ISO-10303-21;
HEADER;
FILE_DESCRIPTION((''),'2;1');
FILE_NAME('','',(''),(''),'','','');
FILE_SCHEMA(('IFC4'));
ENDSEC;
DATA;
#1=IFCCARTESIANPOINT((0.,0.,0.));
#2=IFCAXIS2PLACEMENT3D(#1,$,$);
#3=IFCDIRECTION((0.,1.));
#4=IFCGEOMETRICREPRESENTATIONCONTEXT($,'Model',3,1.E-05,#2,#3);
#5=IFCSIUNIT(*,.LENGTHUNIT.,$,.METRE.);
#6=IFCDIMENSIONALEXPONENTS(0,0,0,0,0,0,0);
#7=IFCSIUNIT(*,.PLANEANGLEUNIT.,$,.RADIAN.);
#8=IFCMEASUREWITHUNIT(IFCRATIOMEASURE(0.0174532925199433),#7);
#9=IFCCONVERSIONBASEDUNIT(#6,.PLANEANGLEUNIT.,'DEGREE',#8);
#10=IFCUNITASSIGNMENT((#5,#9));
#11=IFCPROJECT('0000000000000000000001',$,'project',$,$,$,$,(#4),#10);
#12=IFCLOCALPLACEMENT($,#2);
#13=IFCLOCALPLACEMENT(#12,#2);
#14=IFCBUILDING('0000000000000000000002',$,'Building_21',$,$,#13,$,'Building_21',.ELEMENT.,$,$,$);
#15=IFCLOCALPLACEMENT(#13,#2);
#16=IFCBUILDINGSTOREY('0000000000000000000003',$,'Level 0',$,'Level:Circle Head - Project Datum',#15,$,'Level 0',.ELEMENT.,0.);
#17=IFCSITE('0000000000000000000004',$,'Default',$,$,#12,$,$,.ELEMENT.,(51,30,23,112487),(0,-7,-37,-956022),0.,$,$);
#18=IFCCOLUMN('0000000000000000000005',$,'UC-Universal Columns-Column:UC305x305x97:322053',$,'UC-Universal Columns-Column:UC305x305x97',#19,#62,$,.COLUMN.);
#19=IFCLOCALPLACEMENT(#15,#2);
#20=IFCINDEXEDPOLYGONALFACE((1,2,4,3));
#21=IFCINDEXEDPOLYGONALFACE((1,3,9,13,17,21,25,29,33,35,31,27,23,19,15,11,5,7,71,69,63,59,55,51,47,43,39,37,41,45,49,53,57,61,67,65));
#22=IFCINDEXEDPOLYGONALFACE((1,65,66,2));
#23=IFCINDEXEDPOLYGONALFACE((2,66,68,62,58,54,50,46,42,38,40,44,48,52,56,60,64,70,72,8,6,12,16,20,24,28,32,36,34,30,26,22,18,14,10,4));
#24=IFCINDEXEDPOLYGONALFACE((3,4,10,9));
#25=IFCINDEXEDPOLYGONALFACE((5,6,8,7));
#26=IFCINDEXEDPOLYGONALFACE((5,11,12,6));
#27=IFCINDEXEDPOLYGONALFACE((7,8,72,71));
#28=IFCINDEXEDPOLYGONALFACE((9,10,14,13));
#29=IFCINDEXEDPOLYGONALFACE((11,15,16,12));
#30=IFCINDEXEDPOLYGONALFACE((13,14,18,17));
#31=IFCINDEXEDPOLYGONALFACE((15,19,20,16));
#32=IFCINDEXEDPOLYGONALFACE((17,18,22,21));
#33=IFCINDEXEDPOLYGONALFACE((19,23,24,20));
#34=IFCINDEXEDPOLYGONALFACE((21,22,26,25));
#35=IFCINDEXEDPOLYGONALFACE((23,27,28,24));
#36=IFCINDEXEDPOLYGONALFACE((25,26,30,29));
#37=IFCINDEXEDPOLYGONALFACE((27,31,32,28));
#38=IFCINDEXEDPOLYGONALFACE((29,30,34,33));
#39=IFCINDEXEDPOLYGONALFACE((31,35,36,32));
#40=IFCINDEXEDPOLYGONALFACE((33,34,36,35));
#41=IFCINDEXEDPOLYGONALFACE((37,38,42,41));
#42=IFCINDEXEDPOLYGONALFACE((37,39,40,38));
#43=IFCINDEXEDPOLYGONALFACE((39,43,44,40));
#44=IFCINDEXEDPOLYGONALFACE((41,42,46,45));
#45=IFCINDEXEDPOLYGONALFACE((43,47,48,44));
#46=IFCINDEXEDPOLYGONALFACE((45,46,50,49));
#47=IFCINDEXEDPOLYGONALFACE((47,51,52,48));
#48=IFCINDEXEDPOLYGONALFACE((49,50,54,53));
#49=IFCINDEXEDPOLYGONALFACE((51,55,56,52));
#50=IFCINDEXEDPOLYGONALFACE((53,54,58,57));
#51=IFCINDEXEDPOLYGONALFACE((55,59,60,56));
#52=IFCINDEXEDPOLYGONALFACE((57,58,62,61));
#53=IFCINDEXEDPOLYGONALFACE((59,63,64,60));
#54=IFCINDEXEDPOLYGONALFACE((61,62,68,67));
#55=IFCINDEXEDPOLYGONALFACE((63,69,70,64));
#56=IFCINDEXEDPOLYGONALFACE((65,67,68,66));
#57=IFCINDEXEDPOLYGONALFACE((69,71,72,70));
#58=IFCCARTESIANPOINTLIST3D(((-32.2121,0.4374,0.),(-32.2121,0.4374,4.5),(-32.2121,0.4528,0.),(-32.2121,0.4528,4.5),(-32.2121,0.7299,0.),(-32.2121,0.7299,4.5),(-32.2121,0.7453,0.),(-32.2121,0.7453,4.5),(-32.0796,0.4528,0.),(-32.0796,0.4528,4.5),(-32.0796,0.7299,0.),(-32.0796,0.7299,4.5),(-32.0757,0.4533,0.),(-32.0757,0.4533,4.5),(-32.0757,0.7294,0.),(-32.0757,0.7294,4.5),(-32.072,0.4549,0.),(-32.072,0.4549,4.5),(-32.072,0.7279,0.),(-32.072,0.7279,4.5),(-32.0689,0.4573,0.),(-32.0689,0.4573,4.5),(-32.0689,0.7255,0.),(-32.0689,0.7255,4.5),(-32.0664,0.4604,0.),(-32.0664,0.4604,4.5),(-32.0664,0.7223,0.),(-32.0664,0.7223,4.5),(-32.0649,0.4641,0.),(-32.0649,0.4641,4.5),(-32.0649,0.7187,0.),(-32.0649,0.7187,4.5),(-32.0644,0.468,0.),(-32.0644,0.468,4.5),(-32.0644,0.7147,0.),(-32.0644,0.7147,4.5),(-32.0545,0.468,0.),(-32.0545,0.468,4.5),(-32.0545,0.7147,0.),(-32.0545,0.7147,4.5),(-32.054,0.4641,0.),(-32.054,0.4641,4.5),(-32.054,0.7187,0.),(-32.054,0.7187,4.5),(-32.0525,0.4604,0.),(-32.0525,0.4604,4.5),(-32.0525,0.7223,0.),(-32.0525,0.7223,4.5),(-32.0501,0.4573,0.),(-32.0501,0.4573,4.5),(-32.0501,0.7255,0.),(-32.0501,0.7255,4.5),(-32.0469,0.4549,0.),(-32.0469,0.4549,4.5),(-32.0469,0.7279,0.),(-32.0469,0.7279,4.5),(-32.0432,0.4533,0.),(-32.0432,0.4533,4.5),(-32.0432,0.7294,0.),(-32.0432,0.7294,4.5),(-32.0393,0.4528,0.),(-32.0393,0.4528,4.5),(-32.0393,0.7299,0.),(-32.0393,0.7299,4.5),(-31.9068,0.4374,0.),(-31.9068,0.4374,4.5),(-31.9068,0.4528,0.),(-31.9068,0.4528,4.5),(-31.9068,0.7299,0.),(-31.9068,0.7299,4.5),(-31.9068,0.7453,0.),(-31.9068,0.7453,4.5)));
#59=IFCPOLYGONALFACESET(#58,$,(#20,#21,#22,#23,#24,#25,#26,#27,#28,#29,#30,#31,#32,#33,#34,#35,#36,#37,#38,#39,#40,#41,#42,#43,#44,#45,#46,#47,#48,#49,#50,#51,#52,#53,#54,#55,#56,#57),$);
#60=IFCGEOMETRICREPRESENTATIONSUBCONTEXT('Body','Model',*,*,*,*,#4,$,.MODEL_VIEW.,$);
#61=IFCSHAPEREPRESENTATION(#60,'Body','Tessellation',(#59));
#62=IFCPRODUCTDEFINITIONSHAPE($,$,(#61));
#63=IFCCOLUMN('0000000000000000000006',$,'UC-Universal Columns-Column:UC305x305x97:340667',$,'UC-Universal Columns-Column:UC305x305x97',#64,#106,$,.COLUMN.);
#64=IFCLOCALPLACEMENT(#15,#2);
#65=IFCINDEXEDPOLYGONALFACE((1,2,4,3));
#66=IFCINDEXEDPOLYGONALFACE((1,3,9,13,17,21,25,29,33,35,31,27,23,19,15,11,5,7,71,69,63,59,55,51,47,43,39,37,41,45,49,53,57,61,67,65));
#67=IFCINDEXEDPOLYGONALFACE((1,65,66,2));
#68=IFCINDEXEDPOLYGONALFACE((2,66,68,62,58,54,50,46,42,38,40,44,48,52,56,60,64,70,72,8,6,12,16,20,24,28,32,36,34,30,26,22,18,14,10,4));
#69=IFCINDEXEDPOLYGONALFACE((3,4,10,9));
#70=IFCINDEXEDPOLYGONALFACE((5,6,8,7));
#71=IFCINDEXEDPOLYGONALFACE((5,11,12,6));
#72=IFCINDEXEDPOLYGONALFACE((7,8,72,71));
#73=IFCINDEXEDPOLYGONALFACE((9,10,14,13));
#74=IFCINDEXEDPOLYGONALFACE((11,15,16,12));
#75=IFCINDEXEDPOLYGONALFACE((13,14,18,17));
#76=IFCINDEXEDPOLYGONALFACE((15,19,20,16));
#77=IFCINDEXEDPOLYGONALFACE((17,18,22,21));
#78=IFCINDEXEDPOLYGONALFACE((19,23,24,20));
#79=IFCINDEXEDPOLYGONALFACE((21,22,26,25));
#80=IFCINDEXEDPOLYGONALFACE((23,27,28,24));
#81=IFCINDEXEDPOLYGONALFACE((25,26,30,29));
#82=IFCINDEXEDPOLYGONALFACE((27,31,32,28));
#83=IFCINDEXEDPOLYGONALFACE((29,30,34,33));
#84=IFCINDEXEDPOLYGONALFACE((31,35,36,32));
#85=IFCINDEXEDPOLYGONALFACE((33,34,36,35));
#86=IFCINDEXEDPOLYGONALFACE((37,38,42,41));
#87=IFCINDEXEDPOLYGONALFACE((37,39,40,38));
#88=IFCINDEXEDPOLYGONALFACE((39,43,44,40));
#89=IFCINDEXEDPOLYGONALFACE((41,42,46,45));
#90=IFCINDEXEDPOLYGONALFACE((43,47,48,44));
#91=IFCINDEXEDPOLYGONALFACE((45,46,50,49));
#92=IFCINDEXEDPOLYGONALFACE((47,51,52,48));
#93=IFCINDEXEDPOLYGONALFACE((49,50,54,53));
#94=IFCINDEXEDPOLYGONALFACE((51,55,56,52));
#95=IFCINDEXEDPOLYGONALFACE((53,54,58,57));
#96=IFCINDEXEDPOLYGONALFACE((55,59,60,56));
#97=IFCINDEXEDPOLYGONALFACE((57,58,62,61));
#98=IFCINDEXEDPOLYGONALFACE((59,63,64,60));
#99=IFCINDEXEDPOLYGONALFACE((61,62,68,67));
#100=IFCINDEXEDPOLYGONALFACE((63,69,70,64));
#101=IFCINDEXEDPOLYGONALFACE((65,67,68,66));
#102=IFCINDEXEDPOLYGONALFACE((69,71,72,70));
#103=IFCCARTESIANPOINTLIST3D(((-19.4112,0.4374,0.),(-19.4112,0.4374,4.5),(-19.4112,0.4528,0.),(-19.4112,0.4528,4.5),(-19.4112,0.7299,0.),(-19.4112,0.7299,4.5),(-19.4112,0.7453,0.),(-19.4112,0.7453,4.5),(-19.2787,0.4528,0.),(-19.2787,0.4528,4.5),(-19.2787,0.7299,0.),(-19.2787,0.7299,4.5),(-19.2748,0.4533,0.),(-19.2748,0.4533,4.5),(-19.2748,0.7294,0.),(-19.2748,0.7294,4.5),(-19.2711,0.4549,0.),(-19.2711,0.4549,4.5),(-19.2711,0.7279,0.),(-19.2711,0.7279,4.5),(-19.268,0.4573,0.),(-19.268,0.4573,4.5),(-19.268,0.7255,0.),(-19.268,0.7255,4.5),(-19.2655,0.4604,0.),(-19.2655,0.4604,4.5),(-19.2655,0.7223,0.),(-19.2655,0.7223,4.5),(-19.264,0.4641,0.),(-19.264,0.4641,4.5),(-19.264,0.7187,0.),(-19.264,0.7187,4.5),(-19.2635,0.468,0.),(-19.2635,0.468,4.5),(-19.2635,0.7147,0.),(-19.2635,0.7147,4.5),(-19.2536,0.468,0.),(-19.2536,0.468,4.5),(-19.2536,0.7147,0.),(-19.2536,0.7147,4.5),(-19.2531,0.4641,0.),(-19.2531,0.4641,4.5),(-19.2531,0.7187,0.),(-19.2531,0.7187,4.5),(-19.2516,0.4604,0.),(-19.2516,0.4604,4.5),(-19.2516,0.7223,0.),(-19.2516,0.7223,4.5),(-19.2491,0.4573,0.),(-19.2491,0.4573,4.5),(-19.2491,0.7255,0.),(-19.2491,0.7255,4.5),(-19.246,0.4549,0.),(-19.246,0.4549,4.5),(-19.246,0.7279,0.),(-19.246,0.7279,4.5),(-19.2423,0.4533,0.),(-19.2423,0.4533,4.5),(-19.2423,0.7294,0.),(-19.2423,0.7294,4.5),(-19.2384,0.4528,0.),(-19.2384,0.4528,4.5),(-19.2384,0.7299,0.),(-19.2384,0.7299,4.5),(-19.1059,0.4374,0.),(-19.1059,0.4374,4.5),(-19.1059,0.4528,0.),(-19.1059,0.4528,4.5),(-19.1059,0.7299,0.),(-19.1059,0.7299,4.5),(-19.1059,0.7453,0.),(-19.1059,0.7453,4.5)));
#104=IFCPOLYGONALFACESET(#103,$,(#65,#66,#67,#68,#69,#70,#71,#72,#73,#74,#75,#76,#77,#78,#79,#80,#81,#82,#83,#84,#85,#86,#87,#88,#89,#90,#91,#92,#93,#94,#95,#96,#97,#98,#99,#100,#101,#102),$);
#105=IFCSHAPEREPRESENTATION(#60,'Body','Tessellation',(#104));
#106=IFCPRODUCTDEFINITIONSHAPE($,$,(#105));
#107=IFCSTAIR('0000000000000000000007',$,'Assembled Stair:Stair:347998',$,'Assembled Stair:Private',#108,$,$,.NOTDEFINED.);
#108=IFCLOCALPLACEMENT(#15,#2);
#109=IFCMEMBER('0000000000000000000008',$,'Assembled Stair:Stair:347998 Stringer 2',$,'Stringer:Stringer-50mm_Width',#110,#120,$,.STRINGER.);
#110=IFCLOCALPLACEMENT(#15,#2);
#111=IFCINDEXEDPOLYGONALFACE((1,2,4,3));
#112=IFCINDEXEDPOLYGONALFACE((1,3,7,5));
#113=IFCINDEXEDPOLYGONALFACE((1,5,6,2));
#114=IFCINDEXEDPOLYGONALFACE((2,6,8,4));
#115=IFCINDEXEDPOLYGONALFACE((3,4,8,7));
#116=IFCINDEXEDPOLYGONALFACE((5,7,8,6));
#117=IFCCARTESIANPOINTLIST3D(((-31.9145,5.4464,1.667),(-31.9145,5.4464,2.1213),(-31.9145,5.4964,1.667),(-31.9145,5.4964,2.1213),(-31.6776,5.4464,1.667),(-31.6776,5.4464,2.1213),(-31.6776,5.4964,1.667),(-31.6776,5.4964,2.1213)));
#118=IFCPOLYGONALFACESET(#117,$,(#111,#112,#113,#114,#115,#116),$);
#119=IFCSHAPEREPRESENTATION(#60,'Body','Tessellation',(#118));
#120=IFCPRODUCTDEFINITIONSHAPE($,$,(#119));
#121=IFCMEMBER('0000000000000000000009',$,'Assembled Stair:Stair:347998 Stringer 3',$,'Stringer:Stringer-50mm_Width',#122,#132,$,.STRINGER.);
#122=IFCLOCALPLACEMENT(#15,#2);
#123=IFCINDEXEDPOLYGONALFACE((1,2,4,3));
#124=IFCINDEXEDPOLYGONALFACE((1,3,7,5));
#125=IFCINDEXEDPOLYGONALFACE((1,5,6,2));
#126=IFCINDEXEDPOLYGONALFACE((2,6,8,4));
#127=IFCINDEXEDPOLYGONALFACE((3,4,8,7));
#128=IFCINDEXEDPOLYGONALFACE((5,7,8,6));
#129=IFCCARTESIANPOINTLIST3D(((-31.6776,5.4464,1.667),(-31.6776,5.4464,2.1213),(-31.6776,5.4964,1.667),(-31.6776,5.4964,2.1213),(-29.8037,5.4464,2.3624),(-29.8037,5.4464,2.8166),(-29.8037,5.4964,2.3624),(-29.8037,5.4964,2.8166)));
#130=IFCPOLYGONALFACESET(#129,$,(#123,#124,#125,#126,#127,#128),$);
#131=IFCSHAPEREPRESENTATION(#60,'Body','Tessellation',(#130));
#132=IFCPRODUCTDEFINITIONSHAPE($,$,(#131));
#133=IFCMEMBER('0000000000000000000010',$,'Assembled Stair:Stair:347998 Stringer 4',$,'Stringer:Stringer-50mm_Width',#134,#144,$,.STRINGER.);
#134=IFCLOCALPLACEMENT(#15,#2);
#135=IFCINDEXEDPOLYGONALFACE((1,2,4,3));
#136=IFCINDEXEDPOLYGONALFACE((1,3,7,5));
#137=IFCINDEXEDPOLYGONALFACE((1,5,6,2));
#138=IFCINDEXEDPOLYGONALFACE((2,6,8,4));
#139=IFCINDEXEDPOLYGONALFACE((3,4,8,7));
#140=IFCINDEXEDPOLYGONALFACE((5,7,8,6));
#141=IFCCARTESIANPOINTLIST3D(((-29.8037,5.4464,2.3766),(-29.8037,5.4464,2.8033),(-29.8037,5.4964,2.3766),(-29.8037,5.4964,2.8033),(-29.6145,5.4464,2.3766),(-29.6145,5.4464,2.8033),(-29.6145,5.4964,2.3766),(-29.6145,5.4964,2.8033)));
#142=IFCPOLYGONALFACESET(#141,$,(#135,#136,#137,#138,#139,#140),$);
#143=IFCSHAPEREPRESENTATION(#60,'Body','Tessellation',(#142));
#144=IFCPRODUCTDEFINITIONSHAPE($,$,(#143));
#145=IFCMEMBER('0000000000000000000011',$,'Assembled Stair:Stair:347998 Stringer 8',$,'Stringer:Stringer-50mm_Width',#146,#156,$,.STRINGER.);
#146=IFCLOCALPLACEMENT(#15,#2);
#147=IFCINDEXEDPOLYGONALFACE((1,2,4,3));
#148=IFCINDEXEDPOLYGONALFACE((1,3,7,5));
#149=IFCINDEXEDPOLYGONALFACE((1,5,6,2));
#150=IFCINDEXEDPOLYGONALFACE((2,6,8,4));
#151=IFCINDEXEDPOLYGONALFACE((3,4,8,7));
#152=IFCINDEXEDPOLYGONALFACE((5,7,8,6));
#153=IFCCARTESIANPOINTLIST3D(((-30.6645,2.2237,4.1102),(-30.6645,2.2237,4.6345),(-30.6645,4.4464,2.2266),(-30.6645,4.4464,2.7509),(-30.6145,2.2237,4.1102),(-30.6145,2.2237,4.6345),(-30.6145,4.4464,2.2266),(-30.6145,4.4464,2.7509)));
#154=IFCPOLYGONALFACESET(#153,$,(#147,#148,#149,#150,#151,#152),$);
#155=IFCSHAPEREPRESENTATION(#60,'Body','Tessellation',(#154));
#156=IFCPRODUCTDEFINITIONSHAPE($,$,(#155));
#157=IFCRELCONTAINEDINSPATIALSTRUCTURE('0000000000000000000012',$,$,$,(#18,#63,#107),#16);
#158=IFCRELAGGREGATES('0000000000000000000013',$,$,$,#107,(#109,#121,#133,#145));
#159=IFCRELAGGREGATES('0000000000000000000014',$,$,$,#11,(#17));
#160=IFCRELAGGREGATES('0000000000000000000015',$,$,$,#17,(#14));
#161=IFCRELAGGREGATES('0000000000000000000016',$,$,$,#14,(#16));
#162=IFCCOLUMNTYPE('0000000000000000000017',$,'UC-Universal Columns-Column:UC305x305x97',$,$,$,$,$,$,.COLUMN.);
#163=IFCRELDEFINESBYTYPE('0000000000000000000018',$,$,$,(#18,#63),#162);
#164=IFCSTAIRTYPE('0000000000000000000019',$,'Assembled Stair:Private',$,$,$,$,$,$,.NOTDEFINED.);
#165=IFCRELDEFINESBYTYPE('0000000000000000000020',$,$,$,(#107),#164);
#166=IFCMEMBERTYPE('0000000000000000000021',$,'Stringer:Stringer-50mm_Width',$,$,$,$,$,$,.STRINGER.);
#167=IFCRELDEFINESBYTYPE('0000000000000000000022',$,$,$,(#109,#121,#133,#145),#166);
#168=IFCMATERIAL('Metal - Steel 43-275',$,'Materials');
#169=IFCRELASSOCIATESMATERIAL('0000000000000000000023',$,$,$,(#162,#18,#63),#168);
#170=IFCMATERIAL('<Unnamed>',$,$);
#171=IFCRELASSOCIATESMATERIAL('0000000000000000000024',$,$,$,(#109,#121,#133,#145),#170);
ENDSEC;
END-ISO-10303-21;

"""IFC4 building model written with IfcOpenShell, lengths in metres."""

from ifc_helpers import new_model, entity, si_unit, converted_unit, direction, frame, frame_2d, origin, place, context, subcontext, project, spatial, polyline, circle_curve, parameter, trimmed, segment, composite_curve, rectangle, i_section, outline, extrude, source, transform, mapped, material, material_profile, profile_set, profile_usage, type_object, type_shapes, element, aggregate, save


model = new_model("IFC4")

# Units and contexts
model_context = context("Model", 3, precision=1e-05, world=origin(), true_north=direction((0.0, 1.0)))
body_context = subcontext(model_context, "Body", "Model", "MODEL_VIEW")
ifc_project = project(units=[si_unit("LENGTHUNIT", "METRE"), converted_unit("PLANEANGLEUNIT", "DEGREE", entity("IfcRatioMeasure", 0.0174532925199433), si_unit("PLANEANGLEUNIT", "RADIAN"), dimensions=[0, 0, 0, 0, 0, 0, 0])], contexts=[model_context])

# Site, building, storey
site_placement = place(None, origin())
site = spatial("IfcSite", under=ifc_project, at=site_placement, Name="Default", CompositionType="ELEMENT", RefLatitude=(51, 30, 23, 112487), RefLongitude=(0, -7, -37, -956022), RefElevation=0.0)
building_placement = place(site_placement, origin())
building = spatial("IfcBuilding", under=site, at=building_placement, Name="Building_21", LongName="Building_21", CompositionType="ELEMENT")
storey_placement = place(building_placement, origin())
storey = spatial("IfcBuildingStorey", under=building, at=storey_placement, Name="Level 0", ObjectType="Level:Circle Head - Project Datum", LongName="Level 0", CompositionType="ELEMENT", Elevation=0.0)

# Columns
ifc_material_1 = material(Name="Metal - Steel 43-275", Category="Materials")
ifc_material_profile_1 = material_profile(ifc_material_1, outline(composite_curve([segment(polyline([(-0.1527, 0.154, 0.0), (0.1527, 0.154, 0.0)]), True, "CONTINUOUS"), segment(polyline([(0.1527, 0.154, 0.0), (0.1527, 0.1386, 0.0)]), True, "CONTINUOUS"), segment(polyline([(0.1527, 0.1386, 0.0), (0.0201, 0.1386, 0.0)]), True, "CONTINUOUS"), segment(trimmed(circle_curve(frame((0.0201, 0.1234, 0.0)), 0.0152), [parameter(90.0)], [parameter(180.0)], True, "PARAMETER"), True, "CONTINUOUS"), segment(polyline([(0.0049, 0.1234, 0.0), (0.0049, -0.1234, 0.0)]), True, "CONTINUOUS"), segment(trimmed(circle_curve(frame((0.0201, -0.1234, 0.0)), 0.0152), [parameter(180.0)], [parameter(270.0)], True, "PARAMETER"), True, "CONTINUOUS"), segment(polyline([(0.0201, -0.1386, 0.0), (0.1527, -0.1386, 0.0)]), True, "CONTINUOUS"), segment(polyline([(0.1527, -0.1386, 0.0), (0.1527, -0.154, 0.0)]), True, "CONTINUOUS"), segment(polyline([(0.1527, -0.154, 0.0), (-0.1527, -0.154, 0.0)]), True, "CONTINUOUS"), segment(polyline([(-0.1527, -0.154, 0.0), (-0.1527, -0.1386, 0.0)]), True, "CONTINUOUS"), segment(polyline([(-0.1527, -0.1386, 0.0), (-0.0201, -0.1386, 0.0)]), True, "CONTINUOUS"), segment(trimmed(circle_curve(frame((-0.0201, -0.1234, 0.0)), 0.0152), [parameter(270.0)], [parameter(0.0)], True, "PARAMETER"), True, "CONTINUOUS"), segment(polyline([(-0.0049, -0.1234, 0.0), (-0.005, 0.1234, 0.0)]), True, "CONTINUOUS"), segment(trimmed(circle_curve(frame((-0.0201, 0.1234, 0.0)), 0.0152), [parameter(0.0)], [parameter(90.0)], True, "PARAMETER"), True, "CONTINUOUS"), segment(polyline([(-0.0201, 0.1386, 0.0), (-0.1527, 0.1386, 0.0)]), True, "CONTINUOUS"), segment(polyline([(-0.1527, 0.1386, 0.0), (-0.1527, 0.154, 0.0)]), True, "CONTINUOUS")], self_intersect=False), kind="CURVE"), Name="UC305x305x97")
ifc_material_profile_2 = material_profile(ifc_material_1, outline(composite_curve([segment(polyline([(0.1527, 0.154, 0.0), (0.1527, 0.1386, 0.0)]), True, "CONTINUOUS"), segment(polyline([(0.1527, 0.1386, 0.0), (0.0049, 0.1386, 0.0)]), True, "CONTINUOUS"), segment(polyline([(0.0049, 0.1386, 0.0), (0.0049, -0.1386, 0.0)]), True, "CONTINUOUS"), segment(polyline([(0.0049, -0.1386, 0.0), (0.1527, -0.1386, 0.0)]), True, "CONTINUOUS"), segment(polyline([(0.1527, -0.1386, 0.0), (0.1527, -0.154, 0.0)]), True, "CONTINUOUS"), segment(polyline([(0.1527, -0.154, 0.0), (-0.1527, -0.154, 0.0)]), True, "CONTINUOUS"), segment(polyline([(-0.1527, -0.154, 0.0), (-0.1527, -0.1386, 0.0)]), True, "CONTINUOUS"), segment(polyline([(-0.1527, -0.1386, 0.0), (-0.005, -0.1386, 0.0)]), True, "CONTINUOUS"), segment(polyline([(-0.005, -0.1386, 0.0), (-0.005, 0.1386, 0.0)]), True, "CONTINUOUS"), segment(polyline([(-0.005, 0.1386, 0.0), (-0.1527, 0.1386, 0.0)]), True, "CONTINUOUS"), segment(polyline([(-0.1527, 0.1386, 0.0), (-0.1527, 0.154, 0.0)]), True, "CONTINUOUS"), segment(polyline([(-0.1527, 0.154, 0.0), (0.1527, 0.154, 0.0)]), True, "CONTINUOUS")], self_intersect=False), kind="CURVE"), Name="UC305x305x97")
ifc_profile_set = profile_set([ifc_material_profile_1, ifc_material_profile_2], Name="UC305x305x97")
ifc_profile_usage_1 = profile_usage(ifc_profile_set)
column_type = type_object("IfcColumnType", Name="UC-Universal Columns-Column:UC305x305x97", PredefinedType="COLUMN", material=ifc_profile_set)
shared_shape = source(origin(), body_context, "Body", "SweptSolid", [
    extrude(i_section(OverallWidth=0.3053, OverallDepth=0.3079, WebThickness=0.0099, FlangeThickness=0.0154, FilletRadius=0.0152, at=frame_2d((0.0, 0.0), x_axis=(0.0, 1.0))), frame((0.0, 0.0, 0.0), z_axis=(0.0, 0.0, 1.0), x_axis=(0.0, -1.0, 0.0)), (0.0, 0.0, 1.0), 4.5),
])
type_shapes(column_type, [shared_shape])
column_1_placement = place(storey_placement, frame((-32.0595, 0.5914, 0.0)))
element("IfcColumn", 1, at=column_1_placement, inside=storey, type_object=column_type, material=ifc_profile_usage_1, Name="UC-Universal Columns-Column:UC305x305x97:322053", ObjectType="UC-Universal Columns-Column:UC305x305x97", PredefinedType="COLUMN", context=body_context, shape_type="MappedRepresentation", body=[
    mapped(shared_shape, transform((0.0, 0.0, 0.0), scale=1.0)),
])
ifc_profile_usage_2 = profile_usage(ifc_profile_set)
column_2_placement = place(storey_placement, frame((-19.2586, 0.5914, 0.0)))
element("IfcColumn", 2, at=column_2_placement, inside=storey, type_object=column_type, material=ifc_profile_usage_2, Name="UC-Universal Columns-Column:UC305x305x97:340667", ObjectType="UC-Universal Columns-Column:UC305x305x97", PredefinedType="COLUMN", context=body_context, shape_type="MappedRepresentation", body=[
    mapped(shared_shape, transform((0.0, 0.0, 0.0), scale=1.0)),
])

# Stair, members
stair_type = type_object("IfcStairType", Name="Assembled Stair:Private", PredefinedType="NOTDEFINED")
stair_placement = place(storey_placement, origin())
stair = element("IfcStair", 3, at=stair_placement, inside=storey, type_object=stair_type, Name="Assembled Stair:Stair:347998", ObjectType="Assembled Stair:Private", PredefinedType="NOTDEFINED")
ifc_material_2 = material(Name="<Unnamed>")
member_type = type_object("IfcMemberType", Name="Stringer:Stringer-50mm_Width", PredefinedType="STRINGER")
member_1_placement = place(stair_placement, frame((-31.9145, 5.4464, 1.667)))
member_1 = element("IfcMember", 4, at=member_1_placement, type_object=member_type, material=ifc_material_2, Name="Assembled Stair:Stair:347998 Stringer 2", ObjectType="Stringer:Stringer-50mm_Width", PredefinedType="STRINGER", context=body_context, shape_type="SweptSolid", body=[
    extrude(rectangle(XDim=0.2368, YDim=0.05, at=frame_2d((0.0, 0.0), x_axis=(1.0, 0.0))), frame((0.1184, 0.025, 0.0)), (0.0, 0.0, 1.0), 0.4543),
])
member_2_placement = place(stair_placement, frame((-31.6776, 5.4464, 1.667)))
member_2 = element("IfcMember", 5, at=member_2_placement, type_object=member_type, material=ifc_material_2, Name="Assembled Stair:Stair:347998 Stringer 3", ObjectType="Stringer:Stringer-50mm_Width", PredefinedType="STRINGER", context=body_context, shape_type="SweptSolid", body=[
    extrude(outline(polyline([(-0.9204, -0.213), (1.0784, -0.213), (0.9204, 0.213), (-1.0784, 0.213), (-0.9204, -0.213)])), frame((0.937, 0.0, 0.5748), z_axis=(0.0, 1.0, 0.0), x_axis=(0.937533, 0.0, 0.347896)), (0.0, 0.0, 1.0), 0.05),
])
member_3_placement = place(stair_placement, frame((-29.8037, 5.4464, 2.3766)))
member_3 = element("IfcMember", 6, at=member_3_placement, type_object=member_type, material=ifc_material_2, Name="Assembled Stair:Stair:347998 Stringer 4", ObjectType="Stringer:Stringer-50mm_Width", PredefinedType="STRINGER", context=body_context, shape_type="SweptSolid", body=[
    extrude(rectangle(XDim=0.1893, YDim=0.05, at=frame_2d((0.0, 0.0), x_axis=(1.0, 0.0))), frame((0.0946, 0.025, 0.0)), (0.0, 0.0, 1.0), 0.4267),
])
member_4_placement = place(stair_placement, frame((-30.6645, 2.2237, 2.2266)))
member_4 = element("IfcMember", 7, at=member_4_placement, type_object=member_type, material=ifc_material_2, Name="Assembled Stair:Stair:347998 Stringer 8", ObjectType="Stringer:Stringer-50mm_Width", PredefinedType="STRINGER", context=body_context, shape_type="SweptSolid", body=[
    extrude(outline(polyline([(-1.2872, -0.2), (1.6262, -0.2), (1.2872, 0.2), (-1.6262, 0.2), (-1.2872, -0.2)])), frame((0.0, 1.1113, 1.204), z_axis=(1.0, 0.0, 0.0), x_axis=(0.0, -0.762891, 0.646527)), (0.0, 0.0, 1.0), 0.05),
])
aggregate(stair, [member_1, member_2, member_3, member_4])

save(model, "model.ifc")
